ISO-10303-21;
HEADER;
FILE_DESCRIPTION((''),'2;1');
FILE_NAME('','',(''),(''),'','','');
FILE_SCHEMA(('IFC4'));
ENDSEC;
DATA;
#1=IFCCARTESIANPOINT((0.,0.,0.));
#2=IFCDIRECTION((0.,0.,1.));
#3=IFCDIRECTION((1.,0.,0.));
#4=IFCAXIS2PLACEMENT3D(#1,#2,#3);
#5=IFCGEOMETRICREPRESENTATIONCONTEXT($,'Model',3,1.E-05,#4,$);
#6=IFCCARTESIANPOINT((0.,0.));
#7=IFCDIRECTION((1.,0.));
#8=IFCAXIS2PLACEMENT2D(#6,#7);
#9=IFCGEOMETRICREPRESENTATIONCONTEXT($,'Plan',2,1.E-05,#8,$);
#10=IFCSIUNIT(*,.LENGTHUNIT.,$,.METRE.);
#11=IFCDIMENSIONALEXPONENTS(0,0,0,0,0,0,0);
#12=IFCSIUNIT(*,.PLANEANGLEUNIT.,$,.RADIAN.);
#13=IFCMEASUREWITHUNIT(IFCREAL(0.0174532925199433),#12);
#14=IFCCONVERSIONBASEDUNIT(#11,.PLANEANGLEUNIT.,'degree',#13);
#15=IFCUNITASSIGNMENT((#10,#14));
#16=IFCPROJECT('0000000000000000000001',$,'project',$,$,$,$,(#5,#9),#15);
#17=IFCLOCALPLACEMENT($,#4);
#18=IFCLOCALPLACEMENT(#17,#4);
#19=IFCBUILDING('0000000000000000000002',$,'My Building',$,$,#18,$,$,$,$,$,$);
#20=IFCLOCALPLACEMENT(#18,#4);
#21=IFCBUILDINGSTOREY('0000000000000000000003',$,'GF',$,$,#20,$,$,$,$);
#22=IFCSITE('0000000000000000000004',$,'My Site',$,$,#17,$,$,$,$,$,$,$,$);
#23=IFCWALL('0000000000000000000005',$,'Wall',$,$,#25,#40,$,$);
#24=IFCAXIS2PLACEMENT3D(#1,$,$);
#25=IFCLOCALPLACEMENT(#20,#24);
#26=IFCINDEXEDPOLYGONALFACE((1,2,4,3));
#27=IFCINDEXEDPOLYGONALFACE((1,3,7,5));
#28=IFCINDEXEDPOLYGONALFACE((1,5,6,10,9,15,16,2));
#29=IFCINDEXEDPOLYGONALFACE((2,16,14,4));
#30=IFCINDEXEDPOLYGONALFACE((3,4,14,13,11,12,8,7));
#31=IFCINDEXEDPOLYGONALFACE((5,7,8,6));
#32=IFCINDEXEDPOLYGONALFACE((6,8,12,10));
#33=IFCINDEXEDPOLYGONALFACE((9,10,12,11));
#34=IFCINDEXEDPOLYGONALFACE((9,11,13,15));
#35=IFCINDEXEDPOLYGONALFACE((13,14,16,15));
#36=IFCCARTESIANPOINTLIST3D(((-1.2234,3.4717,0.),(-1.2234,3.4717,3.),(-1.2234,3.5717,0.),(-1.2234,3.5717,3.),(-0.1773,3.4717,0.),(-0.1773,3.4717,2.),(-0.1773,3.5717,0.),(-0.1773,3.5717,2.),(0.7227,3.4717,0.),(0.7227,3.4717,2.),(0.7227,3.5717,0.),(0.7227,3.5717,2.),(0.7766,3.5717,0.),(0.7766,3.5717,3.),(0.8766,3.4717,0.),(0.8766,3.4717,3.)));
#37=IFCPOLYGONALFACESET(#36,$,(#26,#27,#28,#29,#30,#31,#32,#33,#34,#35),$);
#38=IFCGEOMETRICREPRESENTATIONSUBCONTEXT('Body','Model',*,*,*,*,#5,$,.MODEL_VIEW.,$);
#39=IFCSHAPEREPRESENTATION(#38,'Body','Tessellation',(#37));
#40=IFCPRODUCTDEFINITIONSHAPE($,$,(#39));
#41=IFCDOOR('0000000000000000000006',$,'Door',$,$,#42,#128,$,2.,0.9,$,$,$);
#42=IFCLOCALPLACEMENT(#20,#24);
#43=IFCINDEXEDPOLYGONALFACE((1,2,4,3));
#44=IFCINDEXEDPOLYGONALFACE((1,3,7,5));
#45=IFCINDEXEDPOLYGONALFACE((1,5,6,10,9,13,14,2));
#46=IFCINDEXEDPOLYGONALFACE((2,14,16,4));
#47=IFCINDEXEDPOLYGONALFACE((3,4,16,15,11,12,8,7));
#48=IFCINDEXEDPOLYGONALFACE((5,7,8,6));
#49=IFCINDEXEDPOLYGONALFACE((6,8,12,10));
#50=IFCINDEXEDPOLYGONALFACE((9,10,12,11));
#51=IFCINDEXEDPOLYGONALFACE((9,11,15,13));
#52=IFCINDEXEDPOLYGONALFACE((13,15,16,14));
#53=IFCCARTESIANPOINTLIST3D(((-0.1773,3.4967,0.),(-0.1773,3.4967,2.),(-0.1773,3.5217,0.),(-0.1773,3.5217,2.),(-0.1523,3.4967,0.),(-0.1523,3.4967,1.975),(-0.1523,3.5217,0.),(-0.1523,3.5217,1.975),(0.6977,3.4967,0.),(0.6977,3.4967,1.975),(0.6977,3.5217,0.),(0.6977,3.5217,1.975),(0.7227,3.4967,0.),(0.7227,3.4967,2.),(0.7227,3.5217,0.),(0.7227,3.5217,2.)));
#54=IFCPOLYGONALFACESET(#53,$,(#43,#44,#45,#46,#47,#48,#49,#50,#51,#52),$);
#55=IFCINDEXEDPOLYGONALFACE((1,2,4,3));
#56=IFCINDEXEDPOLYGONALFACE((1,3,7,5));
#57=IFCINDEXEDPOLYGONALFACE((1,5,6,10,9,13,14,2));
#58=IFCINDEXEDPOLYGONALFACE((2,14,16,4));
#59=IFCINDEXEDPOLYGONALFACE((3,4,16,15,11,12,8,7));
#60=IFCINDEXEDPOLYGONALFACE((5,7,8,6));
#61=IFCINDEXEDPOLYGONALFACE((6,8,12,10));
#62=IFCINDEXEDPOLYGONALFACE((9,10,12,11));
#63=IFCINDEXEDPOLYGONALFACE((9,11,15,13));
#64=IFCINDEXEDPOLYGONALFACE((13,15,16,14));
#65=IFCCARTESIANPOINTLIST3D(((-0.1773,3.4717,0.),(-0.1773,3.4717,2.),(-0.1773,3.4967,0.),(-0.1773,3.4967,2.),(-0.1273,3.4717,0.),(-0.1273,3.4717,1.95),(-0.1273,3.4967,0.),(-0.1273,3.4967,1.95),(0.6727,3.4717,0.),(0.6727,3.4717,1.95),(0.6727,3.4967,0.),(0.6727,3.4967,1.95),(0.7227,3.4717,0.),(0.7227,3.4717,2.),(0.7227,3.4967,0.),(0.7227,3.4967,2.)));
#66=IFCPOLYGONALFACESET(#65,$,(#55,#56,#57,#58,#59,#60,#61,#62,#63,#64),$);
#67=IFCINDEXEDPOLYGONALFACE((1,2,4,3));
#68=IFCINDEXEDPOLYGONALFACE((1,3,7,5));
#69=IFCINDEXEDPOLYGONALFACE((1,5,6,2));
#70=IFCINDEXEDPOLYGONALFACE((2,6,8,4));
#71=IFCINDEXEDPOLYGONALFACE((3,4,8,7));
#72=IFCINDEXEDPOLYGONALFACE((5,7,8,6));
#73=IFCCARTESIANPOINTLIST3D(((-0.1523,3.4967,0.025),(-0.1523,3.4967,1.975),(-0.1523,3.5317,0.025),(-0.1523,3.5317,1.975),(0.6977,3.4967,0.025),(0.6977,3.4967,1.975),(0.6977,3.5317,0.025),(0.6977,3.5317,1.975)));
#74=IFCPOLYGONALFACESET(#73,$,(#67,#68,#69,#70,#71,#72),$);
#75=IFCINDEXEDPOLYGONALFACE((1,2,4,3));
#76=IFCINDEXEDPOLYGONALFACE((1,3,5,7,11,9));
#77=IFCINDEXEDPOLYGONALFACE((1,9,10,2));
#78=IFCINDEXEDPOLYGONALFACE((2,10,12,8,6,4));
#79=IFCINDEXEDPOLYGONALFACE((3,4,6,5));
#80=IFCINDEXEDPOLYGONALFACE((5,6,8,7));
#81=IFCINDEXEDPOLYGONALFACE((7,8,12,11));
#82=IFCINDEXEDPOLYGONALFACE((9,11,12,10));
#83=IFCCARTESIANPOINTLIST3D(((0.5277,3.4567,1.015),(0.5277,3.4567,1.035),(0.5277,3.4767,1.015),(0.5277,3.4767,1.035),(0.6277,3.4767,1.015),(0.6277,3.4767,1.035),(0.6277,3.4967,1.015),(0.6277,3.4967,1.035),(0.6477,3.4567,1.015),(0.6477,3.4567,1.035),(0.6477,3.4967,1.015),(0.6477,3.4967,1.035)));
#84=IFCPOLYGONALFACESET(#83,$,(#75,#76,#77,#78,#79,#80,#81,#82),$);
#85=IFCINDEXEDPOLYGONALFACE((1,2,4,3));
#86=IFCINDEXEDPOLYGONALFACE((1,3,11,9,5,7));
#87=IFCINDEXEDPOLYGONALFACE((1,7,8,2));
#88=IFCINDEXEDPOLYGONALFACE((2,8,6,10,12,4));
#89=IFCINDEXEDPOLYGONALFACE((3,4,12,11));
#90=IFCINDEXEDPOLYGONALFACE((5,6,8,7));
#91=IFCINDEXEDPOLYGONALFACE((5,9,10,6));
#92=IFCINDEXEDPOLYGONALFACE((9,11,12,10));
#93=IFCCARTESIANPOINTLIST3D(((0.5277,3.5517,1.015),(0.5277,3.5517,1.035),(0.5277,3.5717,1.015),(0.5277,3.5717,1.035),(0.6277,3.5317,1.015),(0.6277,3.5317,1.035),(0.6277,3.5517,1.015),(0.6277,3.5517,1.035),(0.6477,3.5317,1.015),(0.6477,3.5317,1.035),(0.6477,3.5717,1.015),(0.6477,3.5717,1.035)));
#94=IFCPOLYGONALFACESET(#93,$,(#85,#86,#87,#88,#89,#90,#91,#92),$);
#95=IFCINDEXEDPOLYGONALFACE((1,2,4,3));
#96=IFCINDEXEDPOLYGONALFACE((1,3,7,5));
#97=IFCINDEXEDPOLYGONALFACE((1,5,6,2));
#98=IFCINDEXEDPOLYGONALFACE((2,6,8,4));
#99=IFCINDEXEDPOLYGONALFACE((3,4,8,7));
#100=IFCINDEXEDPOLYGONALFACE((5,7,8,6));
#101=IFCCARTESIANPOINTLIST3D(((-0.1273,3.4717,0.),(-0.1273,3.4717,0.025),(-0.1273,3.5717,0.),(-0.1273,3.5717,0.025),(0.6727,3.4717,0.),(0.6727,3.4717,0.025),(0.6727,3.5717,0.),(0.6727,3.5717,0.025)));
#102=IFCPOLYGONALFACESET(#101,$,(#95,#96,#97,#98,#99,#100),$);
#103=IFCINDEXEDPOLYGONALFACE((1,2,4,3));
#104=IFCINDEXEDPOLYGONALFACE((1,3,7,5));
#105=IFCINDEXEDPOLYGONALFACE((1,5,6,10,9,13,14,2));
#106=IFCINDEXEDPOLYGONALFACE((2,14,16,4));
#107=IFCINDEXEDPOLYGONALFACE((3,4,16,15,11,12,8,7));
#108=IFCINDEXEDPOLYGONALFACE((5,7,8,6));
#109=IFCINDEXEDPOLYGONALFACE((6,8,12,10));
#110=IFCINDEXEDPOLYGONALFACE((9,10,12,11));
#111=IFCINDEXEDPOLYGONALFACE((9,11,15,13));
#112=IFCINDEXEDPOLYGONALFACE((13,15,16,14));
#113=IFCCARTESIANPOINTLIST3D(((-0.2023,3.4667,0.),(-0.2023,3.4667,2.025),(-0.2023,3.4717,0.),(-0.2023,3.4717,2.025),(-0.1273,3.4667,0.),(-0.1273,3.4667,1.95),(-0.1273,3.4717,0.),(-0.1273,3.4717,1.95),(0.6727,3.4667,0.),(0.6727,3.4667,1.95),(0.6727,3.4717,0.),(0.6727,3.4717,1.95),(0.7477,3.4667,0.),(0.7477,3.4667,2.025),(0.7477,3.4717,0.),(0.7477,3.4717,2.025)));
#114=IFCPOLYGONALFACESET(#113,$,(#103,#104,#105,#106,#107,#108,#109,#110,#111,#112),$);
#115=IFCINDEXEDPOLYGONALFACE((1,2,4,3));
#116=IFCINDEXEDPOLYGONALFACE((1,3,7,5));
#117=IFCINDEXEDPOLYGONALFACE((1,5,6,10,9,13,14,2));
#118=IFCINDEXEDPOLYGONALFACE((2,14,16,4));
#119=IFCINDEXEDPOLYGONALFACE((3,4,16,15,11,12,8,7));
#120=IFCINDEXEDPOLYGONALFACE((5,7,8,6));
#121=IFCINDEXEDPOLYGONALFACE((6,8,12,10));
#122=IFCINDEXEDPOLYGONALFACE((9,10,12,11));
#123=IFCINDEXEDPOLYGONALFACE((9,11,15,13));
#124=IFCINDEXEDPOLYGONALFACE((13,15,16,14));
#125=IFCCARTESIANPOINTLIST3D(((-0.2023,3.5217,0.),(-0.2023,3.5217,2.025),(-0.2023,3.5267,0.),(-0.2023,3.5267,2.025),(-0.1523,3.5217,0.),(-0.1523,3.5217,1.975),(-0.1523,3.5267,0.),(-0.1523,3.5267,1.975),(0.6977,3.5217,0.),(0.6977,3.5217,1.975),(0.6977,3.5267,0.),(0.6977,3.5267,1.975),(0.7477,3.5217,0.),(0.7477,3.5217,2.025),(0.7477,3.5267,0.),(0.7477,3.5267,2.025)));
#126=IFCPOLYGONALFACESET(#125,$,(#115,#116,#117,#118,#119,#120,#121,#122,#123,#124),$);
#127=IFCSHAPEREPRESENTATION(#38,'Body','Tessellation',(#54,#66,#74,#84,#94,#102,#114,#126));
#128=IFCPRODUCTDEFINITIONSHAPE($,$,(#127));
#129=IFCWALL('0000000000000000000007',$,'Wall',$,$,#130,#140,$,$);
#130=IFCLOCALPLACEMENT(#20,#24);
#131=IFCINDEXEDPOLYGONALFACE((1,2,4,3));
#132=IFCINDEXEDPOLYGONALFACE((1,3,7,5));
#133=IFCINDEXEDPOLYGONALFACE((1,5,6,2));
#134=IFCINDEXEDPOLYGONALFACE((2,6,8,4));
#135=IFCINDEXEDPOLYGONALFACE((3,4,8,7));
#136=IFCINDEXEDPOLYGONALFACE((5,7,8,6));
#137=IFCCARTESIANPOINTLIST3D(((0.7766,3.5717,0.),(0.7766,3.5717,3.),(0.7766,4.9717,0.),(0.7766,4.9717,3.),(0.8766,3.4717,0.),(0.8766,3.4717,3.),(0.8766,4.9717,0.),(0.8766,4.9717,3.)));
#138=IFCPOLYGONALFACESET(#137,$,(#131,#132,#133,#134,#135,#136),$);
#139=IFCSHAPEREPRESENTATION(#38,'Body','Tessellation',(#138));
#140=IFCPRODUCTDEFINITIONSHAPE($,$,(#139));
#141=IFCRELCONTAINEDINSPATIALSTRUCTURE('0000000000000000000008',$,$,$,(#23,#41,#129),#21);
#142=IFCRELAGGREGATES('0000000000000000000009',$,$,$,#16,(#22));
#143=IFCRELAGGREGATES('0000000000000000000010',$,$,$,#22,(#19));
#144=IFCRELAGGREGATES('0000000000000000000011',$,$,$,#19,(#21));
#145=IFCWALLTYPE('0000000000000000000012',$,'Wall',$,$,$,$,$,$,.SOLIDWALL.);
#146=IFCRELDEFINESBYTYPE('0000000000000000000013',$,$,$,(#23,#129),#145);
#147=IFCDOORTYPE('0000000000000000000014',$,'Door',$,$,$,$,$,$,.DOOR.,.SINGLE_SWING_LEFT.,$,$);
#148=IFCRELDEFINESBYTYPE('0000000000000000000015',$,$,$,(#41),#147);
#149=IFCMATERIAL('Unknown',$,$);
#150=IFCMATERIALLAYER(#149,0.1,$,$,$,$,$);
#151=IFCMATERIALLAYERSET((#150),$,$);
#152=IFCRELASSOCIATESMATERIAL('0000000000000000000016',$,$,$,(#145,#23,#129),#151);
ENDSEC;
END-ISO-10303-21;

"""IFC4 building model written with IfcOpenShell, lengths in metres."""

from ifc_helpers import new_model, entity, si_unit, converted_unit, frame, origin_with_axes, origin_2d_with_axis, place, context, subcontext, project, spatial, line, indexed_curve, outline, extrude, shape, source, transform, mapped, material, layer, layer_set, layer_usage, type_object, type_shapes, element, fill, save


model = new_model("IFC4")

# Units and contexts
model_context = context("Model", 3, precision=1e-05, world=origin_with_axes())
plan_context = context("Plan", 2, precision=1e-05, world=origin_2d_with_axis())
body_context_1 = subcontext(model_context, "Body", "Model", "MODEL_VIEW")
body_context_2 = subcontext(plan_context, "Body", "Plan", "PLAN_VIEW")
ifc_project = project(units=[si_unit("LENGTHUNIT", "METRE"), converted_unit("PLANEANGLEUNIT", "degree", entity("IfcReal", 0.0174532925199433), si_unit("PLANEANGLEUNIT", "RADIAN"), dimensions=[0, 0, 0, 0, 0, 0, 0])], contexts=[model_context, plan_context])

# Site, building, storey
site_placement = place(None, origin_with_axes())
site = spatial("IfcSite", under=ifc_project, at=site_placement, Name="My Site")
building_placement = place(site_placement, origin_with_axes())
building = spatial("IfcBuilding", under=site, at=building_placement, Name="My Building")
storey_placement = place(building_placement, origin_with_axes())
storey = spatial("IfcBuildingStorey", under=building, at=storey_placement, Name="GF")

# Shared definitions
ifc_material_1 = material(Name="Unknown")

# Shared definitions
ifc_layer_1 = layer(ifc_material_1, 0.1)
ifc_layer_set_1 = layer_set([ifc_layer_1])
wall_type = type_object("IfcWallType", Name="Wall", PredefinedType="SOLIDWALL", material=ifc_layer_set_1)
shared_shape_1 = source(origin_with_axes(), body_context_1, "Body", "SweptSolid", [
    extrude(outline(indexed_curve([(0.0, 0.0), (0.9, 0.0), (0.9, 2.0), (0.0, 2.0)], segments=[line(1, 2, 3, 4, 1)])), frame((0.0, -0.6, 0.0), z_axis=(0.0, -1.0, 0.0), x_axis=(1.0, 0.0, 0.0)), (0.0, 0.0, -1.0), 1.2),
])
door_type = type_object("IfcDoorType", Name="Door", OperationType="SINGLE_SWING_LEFT", PredefinedType="DOOR")
shared_shape_2 = source(origin_with_axes(), body_context_1, "Body", "SweptSolid", [
    extrude(outline(indexed_curve([(0.0, 0.0), (0.0, 2.0), (0.9, 2.0), (0.9, 0.0), (0.875, 0.0), (0.875, 1.975), (0.025, 1.975), (0.025, 0.0)], segments=[line(1, 2, 3, 4, 5, 6, 7, 8, 1)])), frame((0.0, 0.025, 0.0), z_axis=(0.0, -1.0, 0.0), x_axis=(1.0, 0.0, 0.0)), (0.0, 0.0, -1.0), 0.025),
    extrude(outline(indexed_curve([(0.0, 0.0), (0.0, 2.0), (0.9, 2.0), (0.9, 0.0), (0.85, 0.0), (0.85, 1.95), (0.05, 1.95), (0.05, 0.0)], segments=[line(1, 2, 3, 4, 5, 6, 7, 8, 1)])), frame((0.0, 0.0, 0.0), z_axis=(0.0, -1.0, 0.0), x_axis=(1.0, 0.0, 0.0)), (0.0, 0.0, -1.0), 0.025),
    extrude(outline(indexed_curve([(0.0, 0.0), (0.85, 0.0), (0.85, 0.035), (0.0, 0.035)], segments=[line(1, 2, 3, 4, 1)])), frame((0.025, 0.025, 0.025), z_axis=(0.0, 0.0, 1.0), x_axis=(1.0, 0.0, 0.0)), (0.0, 0.0, 1.0), 1.95),
    extrude(outline(indexed_curve([(0.0, 0.0), (0.0, -0.04), (-0.12, -0.04), (-0.12, -0.02), (-0.02, -0.02), (-0.02, 0.0)], segments=[line(1, 2, 3, 4, 5, 6, 1)])), frame((0.825, 0.025, 1.015), z_axis=(0.0, 0.0, 1.0), x_axis=(1.0, 0.0, 0.0)), (0.0, 0.0, 1.0), 0.02),
    extrude(outline(indexed_curve([(0.0, 0.0), (0.0, 0.04), (-0.12, 0.04), (-0.12, 0.02), (-0.02, 0.02), (-0.02, 0.0)], segments=[line(1, 2, 3, 4, 5, 6, 1)])), frame((0.825, 0.06, 1.015), z_axis=(0.0, 0.0, 1.0), x_axis=(1.0, 0.0, 0.0)), (0.0, 0.0, 1.0), 0.02),
    extrude(outline(indexed_curve([(0.0, 0.0), (0.8, 0.0), (0.8, 0.1), (0.0, 0.1)], segments=[line(1, 2, 3, 4, 1)])), frame((0.05, 0.0, 0.0), z_axis=(0.0, 0.0, 1.0), x_axis=(1.0, 0.0, 0.0)), (0.0, 0.0, 1.0), 0.025),
    extrude(outline(indexed_curve([(0.0, 0.0), (0.0, 2.025), (0.95, 2.025), (0.95, 0.0), (0.875, 0.0), (0.875, 1.95), (0.075, 1.95), (0.075, 0.0)], segments=[line(1, 2, 3, 4, 5, 6, 7, 8, 1)])), frame((-0.025, -0.005, 0.0), z_axis=(0.0, -1.0, 0.0), x_axis=(1.0, 0.0, 0.0)), (0.0, 0.0, -1.0), 0.005),
    extrude(outline(indexed_curve([(0.0, 0.0), (0.0, 2.025), (0.95, 2.025), (0.95, 0.0), (0.9, 0.0), (0.9, 1.975), (0.05, 1.975), (0.05, 0.0)], segments=[line(1, 2, 3, 4, 5, 6, 7, 8, 1)])), frame((-0.025, 0.05, 0.0), z_axis=(0.0, -1.0, 0.0), x_axis=(1.0, 0.0, 0.0)), (0.0, 0.0, -1.0), 0.005),
])
shared_shape_3 = source(origin_with_axes(), body_context_2, "Body", "Curve2D", [
    entity("IfcIndexedPolyCurve", entity("IfcCartesianPointList2D", [[0.0, 0.0], [0.0, 0.05], [0.025, 0.05], [0.025, 0.025], [0.05, 0.025], [0.05, 0.0]]), [entity("IfcLineIndex", [1, 2, 3, 4, 5, 6, 1])]),
    entity("IfcIndexedPolyCurve", entity("IfcCartesianPointList2D", [[0.9, 0.0], [0.9, 0.05], [0.875, 0.05], [0.875, 0.025], [0.85, 0.025], [0.85, 0.0]]), [entity("IfcLineIndex", [1, 2, 3, 4, 5, 6, 1])]),
    entity("IfcTrimmedCurve", entity("IfcEllipse", entity("IfcAxis2Placement2D", entity("IfcCartesianPoint", [0.06, 0.05]), entity("IfcDirection", [1.0, 0.0])), 0.815, 0.85), [entity("IfcCartesianPoint", [0.875, 0.05])], [entity("IfcCartesianPoint", [0.06, 0.9])], True, "CARTESIAN"),
    entity("IfcIndexedPolyCurve", entity("IfcCartesianPointList2D", [[0.025, 0.05], [0.06, 0.05], [0.06, 0.9], [0.025, 0.9]]), [entity("IfcLineIndex", [1, 2, 3, 4, 1])]),
])
type_shapes(door_type, [shared_shape_2, shared_shape_3])

# Wall, opening, door
ifc_layer_usage_1 = layer_usage(ifc_layer_set_1, "AXIS2", "POSITIVE", 0.0)
wall_1_placement = place(storey_placement, frame((-1.2234, 3.4717, 0.0), z_axis=(0.0, 0.0, 1.0), x_axis=(1.0, 0.0, 0.0)))
wall_1 = element("IfcWall", 1, at=wall_1_placement, inside=storey, type_object=wall_type, material=ifc_layer_usage_1, Name="Wall", context=body_context_1, shape_type="SweptSolid", body=[
    extrude(outline(indexed_curve([(0.0, 0.0), (0.0, 0.1), (2.0, 0.1), (2.1, 0.0)], segments=[line(1, 2, 3, 4, 1)])), origin_with_axes(), (0.0, 0.0, 1.0), 3.0),
])
opening_1_placement = place(wall_1_placement, frame((1.046, 0.0, 0.0), z_axis=(0.0, 0.0, 1.0), x_axis=(1.0, 0.0, 0.0)))
opening_1 = element("IfcOpeningElement", 2, at=opening_1_placement, cuts=wall_1, PredefinedType="OPENING", context=body_context_1, shape_type="MappedRepresentation", body=[
    mapped(shared_shape_1, transform((0.0, 0.0, 0.0), x_axis=(1.0, 0.0, 0.0), y_axis=(0.0, 1.0, 0.0), z_axis=(0.0, 0.0, 1.0), scale=1.0)),
])
door_1_placement = place(opening_1_placement, origin_with_axes())
door_1 = element("IfcDoor", 3, at=door_1_placement, inside=storey, type_object=door_type, Name="Door", OverallHeight=2.0, OverallWidth=0.9, shapes=[
    shape(body_context_1, "Body", "MappedRepresentation", [mapped(shared_shape_2, transform((0.0, 0.0, 0.0), x_axis=(1.0, 0.0, 0.0), y_axis=(0.0, 1.0, 0.0), z_axis=(0.0, 0.0, 1.0), scale=1.0))]),
    shape(body_context_2, "Body", "MappedRepresentation", [mapped(shared_shape_3, transform((0.0, 0.0, 0.0), x_axis=(1.0, 0.0, 0.0), y_axis=(0.0, 1.0, 0.0), z_axis=(0.0, 0.0, 1.0), scale=1.0))]),
])
fill(opening_1, door_1)

# Wall
ifc_layer_usage_2 = layer_usage(ifc_layer_set_1, "AXIS2", "POSITIVE", 0.0)
wall_2_placement = place(storey_placement, frame((0.8766, 3.4717, 0.0), z_axis=(0.0, 0.0, 1.0), x_axis=(0.0, 1.0, 0.0)))
element("IfcWall", 4, at=wall_2_placement, inside=storey, type_object=wall_type, material=ifc_layer_usage_2, Name="Wall", context=body_context_1, shape_type="SweptSolid", body=[
    extrude(outline(indexed_curve([(0.0, 0.0), (0.1, 0.1), (1.5, 0.1), (1.5, 0.0)], segments=[line(1, 2, 3, 4, 1)])), origin_with_axes(), (0.0, 0.0, 1.0), 3.0),
])

save(model, "model.ifc")
